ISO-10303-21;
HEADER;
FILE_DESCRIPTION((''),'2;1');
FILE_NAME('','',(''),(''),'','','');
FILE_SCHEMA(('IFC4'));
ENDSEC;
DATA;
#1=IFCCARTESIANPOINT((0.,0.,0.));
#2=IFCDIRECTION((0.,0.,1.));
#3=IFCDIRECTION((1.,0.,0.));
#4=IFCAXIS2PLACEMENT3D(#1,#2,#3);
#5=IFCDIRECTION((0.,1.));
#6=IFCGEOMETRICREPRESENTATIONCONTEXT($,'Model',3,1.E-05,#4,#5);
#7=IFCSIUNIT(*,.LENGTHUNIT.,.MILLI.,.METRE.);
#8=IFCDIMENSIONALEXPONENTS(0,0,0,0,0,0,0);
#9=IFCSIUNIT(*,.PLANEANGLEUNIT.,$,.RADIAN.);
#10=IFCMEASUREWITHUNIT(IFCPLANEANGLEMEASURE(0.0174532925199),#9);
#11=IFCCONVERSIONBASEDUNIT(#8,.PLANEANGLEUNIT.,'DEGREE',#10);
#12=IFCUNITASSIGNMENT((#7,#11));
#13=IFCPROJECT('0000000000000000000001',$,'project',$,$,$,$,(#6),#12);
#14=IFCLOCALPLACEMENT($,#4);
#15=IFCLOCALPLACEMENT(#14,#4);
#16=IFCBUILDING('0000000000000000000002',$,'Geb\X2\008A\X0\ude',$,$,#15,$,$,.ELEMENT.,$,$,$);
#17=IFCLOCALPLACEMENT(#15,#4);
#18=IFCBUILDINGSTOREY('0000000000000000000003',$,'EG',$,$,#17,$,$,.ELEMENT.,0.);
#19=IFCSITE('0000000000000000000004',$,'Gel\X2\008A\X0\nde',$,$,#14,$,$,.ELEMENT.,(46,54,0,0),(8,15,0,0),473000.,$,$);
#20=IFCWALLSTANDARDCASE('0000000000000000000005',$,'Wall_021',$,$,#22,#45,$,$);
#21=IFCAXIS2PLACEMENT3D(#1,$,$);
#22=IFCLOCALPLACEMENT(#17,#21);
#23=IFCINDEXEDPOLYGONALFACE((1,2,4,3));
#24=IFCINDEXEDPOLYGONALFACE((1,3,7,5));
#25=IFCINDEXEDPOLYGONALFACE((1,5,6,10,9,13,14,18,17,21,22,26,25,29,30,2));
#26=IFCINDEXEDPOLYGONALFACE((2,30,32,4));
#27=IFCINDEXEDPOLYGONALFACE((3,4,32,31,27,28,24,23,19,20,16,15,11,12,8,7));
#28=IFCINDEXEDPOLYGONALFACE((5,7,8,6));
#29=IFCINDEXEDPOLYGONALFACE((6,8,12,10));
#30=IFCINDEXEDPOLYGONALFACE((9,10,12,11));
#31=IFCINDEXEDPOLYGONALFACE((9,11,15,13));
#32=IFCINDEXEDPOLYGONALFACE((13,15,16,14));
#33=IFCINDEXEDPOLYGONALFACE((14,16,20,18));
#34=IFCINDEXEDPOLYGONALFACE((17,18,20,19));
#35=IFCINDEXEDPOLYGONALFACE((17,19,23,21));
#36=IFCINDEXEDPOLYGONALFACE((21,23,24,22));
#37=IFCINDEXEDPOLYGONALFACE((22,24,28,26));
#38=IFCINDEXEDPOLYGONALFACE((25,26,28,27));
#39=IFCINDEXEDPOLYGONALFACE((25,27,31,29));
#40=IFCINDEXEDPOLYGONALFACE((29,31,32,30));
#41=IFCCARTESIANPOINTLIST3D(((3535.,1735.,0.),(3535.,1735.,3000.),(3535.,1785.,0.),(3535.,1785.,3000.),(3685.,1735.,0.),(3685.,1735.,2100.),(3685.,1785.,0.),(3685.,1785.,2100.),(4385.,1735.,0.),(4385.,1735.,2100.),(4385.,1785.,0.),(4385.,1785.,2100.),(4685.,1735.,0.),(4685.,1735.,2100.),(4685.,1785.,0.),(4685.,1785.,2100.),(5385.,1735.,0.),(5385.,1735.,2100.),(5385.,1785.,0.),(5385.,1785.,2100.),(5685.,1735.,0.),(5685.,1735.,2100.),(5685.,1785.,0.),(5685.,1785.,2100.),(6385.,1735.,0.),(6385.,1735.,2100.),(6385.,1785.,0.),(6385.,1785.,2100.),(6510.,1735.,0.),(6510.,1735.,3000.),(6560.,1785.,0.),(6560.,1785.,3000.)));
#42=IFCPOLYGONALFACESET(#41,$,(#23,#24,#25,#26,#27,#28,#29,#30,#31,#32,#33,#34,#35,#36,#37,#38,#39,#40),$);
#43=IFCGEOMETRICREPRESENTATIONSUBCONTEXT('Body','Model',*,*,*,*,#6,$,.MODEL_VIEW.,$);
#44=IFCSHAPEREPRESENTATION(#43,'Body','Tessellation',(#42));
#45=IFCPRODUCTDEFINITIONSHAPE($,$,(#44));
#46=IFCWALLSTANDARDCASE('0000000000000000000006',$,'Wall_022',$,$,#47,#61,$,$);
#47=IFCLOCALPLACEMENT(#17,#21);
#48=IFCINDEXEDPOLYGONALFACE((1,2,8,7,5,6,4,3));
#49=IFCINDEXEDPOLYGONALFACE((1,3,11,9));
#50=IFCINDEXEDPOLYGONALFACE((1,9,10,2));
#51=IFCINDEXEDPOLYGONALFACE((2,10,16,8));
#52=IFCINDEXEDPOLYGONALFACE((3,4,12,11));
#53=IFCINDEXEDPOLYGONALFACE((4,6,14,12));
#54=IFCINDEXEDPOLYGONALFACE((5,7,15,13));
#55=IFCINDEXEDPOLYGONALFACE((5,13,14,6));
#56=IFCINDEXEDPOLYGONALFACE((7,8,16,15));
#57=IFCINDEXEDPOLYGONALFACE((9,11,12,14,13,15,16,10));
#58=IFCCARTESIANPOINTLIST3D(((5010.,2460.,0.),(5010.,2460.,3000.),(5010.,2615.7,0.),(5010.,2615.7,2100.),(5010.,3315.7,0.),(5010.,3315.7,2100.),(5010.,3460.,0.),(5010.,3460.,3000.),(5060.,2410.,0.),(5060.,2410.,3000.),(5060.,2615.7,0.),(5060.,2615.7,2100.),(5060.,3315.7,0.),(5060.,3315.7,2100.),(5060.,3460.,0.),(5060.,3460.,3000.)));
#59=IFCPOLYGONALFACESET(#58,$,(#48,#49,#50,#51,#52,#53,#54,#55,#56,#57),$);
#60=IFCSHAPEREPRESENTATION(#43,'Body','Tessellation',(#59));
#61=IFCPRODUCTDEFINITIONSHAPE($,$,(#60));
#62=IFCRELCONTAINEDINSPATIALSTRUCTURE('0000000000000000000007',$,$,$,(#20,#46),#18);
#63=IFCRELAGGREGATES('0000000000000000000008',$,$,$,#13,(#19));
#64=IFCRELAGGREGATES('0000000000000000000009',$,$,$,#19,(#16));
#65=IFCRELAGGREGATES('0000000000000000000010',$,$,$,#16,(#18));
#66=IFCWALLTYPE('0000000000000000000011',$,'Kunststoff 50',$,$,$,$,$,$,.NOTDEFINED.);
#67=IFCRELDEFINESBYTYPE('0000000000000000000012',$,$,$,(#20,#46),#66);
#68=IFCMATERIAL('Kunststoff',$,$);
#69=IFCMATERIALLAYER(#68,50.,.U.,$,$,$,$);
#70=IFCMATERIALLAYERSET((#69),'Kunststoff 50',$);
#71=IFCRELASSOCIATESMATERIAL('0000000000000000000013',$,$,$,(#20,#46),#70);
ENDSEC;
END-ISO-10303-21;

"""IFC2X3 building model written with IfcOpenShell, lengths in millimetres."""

from ifc_helpers import new_model, entity, si_unit, converted_unit, direction, frame, origin_with_axes, origin_2d_with_axis, place, context, subcontext, project, spatial, polyline, rectangle, outline, extrude, material, layer, layer_set, layer_usage, type_object, element, save


model = new_model("IFC2X3")

# Units and contexts
model_context = context("Model", 3, precision=1e-05, world=origin_with_axes(), true_north=direction((0.0, 1.0)))
body_context = subcontext(model_context, "Body", "Model", "MODEL_VIEW")
ifc_project = project(units=[si_unit("LENGTHUNIT", "METRE", prefix="MILLI"), converted_unit("PLANEANGLEUNIT", "DEGREE", entity("IfcPlaneAngleMeasure", 0.0174532925199), si_unit("PLANEANGLEUNIT", "RADIAN"), dimensions=[0, 0, 0, 0, 0, 0, 0])], contexts=[model_context])

# Site, building, storey
site_placement = place(None, origin_with_axes())
site = spatial("IfcSite", under=ifc_project, at=site_placement, Name="Gel\u008ande", CompositionType="ELEMENT", RefLatitude=(46, 54, 0, 0), RefLongitude=(8, 15, 0, 0), RefElevation=473000.0)
building_placement = place(site_placement, origin_with_axes())
building = spatial("IfcBuilding", under=site, at=building_placement, Name="Geb\u008aude", CompositionType="ELEMENT")
storey_placement = place(building_placement, origin_with_axes())
storey = spatial("IfcBuildingStorey", under=building, at=storey_placement, Name="EG", CompositionType="ELEMENT", Elevation=0.0)

# Shared definitions
ifc_material_1 = material(Name="Kunststoff")
ifc_layer_1 = layer(ifc_material_1, 50.0, ventilated="UNKNOWN")
ifc_layer_set_1 = layer_set([ifc_layer_1], Name="Kunststoff 50")
wall_type_1 = type_object("IfcWallType", Name="Kunststoff 50", PredefinedType="NOTDEFINED")

# Wall, openings
ifc_layer_usage_1 = layer_usage(ifc_layer_set_1, "AXIS2", "POSITIVE", -25.0)
wall_1_placement = place(storey_placement, frame((6535.0, 1760.0, 0.0), z_axis=(0.0, 0.0, 1.0), x_axis=(-1.0, 0.0, 0.0)))
wall_1 = element("IfcWallStandardCase", 1, at=wall_1_placement, inside=storey, type_object=wall_type_1, material=ifc_layer_usage_1, Name="Wall_021", context=body_context, shape_type="SweptSolid", body=[
    extrude(outline(polyline([(-25.0, -25.0), (3000.0, -25.0), (3000.0, 25.0), (25.0, 25.0), (-25.0, -25.0)])), origin_with_axes(), (0.0, 0.0, 1.0), 3000.0),
])
opening_1_placement = place(wall_1_placement, frame((2500.0, 0.0, 0.0), z_axis=(0.0, 0.0, 1.0), x_axis=(1.0, 0.0, 0.0)))
element("IfcOpeningElement", 2, at=opening_1_placement, cuts=wall_1, context=body_context, shape_type="SweptSolid", body=[
    extrude(rectangle(XDim=700.0, YDim=2100.0, at=origin_2d_with_axis()), frame((0.0, -50.0, 1050.0), z_axis=(0.0, -1.0, 0.0), x_axis=(-1.0, 0.0, 0.0)), (0.0, 0.0, -1.0), 150.0),
])
opening_2_placement = place(wall_1_placement, frame((1500.0, 0.0, 0.0), z_axis=(0.0, 0.0, 1.0), x_axis=(1.0, 0.0, 0.0)))
element("IfcOpeningElement", 3, at=opening_2_placement, cuts=wall_1, context=body_context, shape_type="SweptSolid", body=[
    extrude(rectangle(XDim=700.0, YDim=2100.0, at=origin_2d_with_axis()), frame((0.0, -50.0, 1050.0), z_axis=(0.0, -1.0, 0.0), x_axis=(-1.0, 0.0, 0.0)), (0.0, 0.0, -1.0), 150.0),
])
opening_3_placement = place(wall_1_placement, frame((500.0, 0.0, 0.0), z_axis=(0.0, 0.0, 1.0), x_axis=(1.0, 0.0, 0.0)))
element("IfcOpeningElement", 4, at=opening_3_placement, cuts=wall_1, context=body_context, shape_type="SweptSolid", body=[
    extrude(rectangle(XDim=700.0, YDim=2100.0, at=origin_2d_with_axis()), frame((0.0, -50.0, 1050.0), z_axis=(0.0, -1.0, 0.0), x_axis=(-1.0, 0.0, 0.0)), (0.0, 0.0, -1.0), 150.0),
])

# Wall, opening
ifc_layer_usage_2 = layer_usage(ifc_layer_set_1, "AXIS2", "NEGATIVE", 25.0)
wall_2_placement = place(storey_placement, frame((5035.0, 3460.0, 0.0), z_axis=(0.0, 0.0, 1.0), x_axis=(0.0, -1.0, 0.0)))
wall_2 = element("IfcWallStandardCase", 5, at=wall_2_placement, inside=storey, type_object=wall_type_1, material=ifc_layer_usage_2, Name="Wall_022", context=body_context, shape_type="SweptSolid", body=[
    extrude(outline(polyline([(0.0, -25.0), (1000.0, -25.0), (1050.0, 25.0), (0.0, 25.0), (0.0, -25.0)])), origin_with_axes(), (0.0, 0.0, 1.0), 3000.0),
])
opening_4_placement = place(wall_2_placement, frame((494.3, 0.0, 0.0), z_axis=(0.0, 0.0, 1.0), x_axis=(1.0, 0.0, 0.0)))
element("IfcOpeningElement", 6, at=opening_4_placement, cuts=wall_2, context=body_context, shape_type="SweptSolid", body=[
    extrude(rectangle(XDim=700.0, YDim=2100.0, at=origin_2d_with_axis()), frame((0.0, -50.0, 1050.0), z_axis=(0.0, -1.0, 0.0), x_axis=(-1.0, 0.0, 0.0)), (0.0, 0.0, -1.0), 150.0),
])

save(model, "model.ifc")
